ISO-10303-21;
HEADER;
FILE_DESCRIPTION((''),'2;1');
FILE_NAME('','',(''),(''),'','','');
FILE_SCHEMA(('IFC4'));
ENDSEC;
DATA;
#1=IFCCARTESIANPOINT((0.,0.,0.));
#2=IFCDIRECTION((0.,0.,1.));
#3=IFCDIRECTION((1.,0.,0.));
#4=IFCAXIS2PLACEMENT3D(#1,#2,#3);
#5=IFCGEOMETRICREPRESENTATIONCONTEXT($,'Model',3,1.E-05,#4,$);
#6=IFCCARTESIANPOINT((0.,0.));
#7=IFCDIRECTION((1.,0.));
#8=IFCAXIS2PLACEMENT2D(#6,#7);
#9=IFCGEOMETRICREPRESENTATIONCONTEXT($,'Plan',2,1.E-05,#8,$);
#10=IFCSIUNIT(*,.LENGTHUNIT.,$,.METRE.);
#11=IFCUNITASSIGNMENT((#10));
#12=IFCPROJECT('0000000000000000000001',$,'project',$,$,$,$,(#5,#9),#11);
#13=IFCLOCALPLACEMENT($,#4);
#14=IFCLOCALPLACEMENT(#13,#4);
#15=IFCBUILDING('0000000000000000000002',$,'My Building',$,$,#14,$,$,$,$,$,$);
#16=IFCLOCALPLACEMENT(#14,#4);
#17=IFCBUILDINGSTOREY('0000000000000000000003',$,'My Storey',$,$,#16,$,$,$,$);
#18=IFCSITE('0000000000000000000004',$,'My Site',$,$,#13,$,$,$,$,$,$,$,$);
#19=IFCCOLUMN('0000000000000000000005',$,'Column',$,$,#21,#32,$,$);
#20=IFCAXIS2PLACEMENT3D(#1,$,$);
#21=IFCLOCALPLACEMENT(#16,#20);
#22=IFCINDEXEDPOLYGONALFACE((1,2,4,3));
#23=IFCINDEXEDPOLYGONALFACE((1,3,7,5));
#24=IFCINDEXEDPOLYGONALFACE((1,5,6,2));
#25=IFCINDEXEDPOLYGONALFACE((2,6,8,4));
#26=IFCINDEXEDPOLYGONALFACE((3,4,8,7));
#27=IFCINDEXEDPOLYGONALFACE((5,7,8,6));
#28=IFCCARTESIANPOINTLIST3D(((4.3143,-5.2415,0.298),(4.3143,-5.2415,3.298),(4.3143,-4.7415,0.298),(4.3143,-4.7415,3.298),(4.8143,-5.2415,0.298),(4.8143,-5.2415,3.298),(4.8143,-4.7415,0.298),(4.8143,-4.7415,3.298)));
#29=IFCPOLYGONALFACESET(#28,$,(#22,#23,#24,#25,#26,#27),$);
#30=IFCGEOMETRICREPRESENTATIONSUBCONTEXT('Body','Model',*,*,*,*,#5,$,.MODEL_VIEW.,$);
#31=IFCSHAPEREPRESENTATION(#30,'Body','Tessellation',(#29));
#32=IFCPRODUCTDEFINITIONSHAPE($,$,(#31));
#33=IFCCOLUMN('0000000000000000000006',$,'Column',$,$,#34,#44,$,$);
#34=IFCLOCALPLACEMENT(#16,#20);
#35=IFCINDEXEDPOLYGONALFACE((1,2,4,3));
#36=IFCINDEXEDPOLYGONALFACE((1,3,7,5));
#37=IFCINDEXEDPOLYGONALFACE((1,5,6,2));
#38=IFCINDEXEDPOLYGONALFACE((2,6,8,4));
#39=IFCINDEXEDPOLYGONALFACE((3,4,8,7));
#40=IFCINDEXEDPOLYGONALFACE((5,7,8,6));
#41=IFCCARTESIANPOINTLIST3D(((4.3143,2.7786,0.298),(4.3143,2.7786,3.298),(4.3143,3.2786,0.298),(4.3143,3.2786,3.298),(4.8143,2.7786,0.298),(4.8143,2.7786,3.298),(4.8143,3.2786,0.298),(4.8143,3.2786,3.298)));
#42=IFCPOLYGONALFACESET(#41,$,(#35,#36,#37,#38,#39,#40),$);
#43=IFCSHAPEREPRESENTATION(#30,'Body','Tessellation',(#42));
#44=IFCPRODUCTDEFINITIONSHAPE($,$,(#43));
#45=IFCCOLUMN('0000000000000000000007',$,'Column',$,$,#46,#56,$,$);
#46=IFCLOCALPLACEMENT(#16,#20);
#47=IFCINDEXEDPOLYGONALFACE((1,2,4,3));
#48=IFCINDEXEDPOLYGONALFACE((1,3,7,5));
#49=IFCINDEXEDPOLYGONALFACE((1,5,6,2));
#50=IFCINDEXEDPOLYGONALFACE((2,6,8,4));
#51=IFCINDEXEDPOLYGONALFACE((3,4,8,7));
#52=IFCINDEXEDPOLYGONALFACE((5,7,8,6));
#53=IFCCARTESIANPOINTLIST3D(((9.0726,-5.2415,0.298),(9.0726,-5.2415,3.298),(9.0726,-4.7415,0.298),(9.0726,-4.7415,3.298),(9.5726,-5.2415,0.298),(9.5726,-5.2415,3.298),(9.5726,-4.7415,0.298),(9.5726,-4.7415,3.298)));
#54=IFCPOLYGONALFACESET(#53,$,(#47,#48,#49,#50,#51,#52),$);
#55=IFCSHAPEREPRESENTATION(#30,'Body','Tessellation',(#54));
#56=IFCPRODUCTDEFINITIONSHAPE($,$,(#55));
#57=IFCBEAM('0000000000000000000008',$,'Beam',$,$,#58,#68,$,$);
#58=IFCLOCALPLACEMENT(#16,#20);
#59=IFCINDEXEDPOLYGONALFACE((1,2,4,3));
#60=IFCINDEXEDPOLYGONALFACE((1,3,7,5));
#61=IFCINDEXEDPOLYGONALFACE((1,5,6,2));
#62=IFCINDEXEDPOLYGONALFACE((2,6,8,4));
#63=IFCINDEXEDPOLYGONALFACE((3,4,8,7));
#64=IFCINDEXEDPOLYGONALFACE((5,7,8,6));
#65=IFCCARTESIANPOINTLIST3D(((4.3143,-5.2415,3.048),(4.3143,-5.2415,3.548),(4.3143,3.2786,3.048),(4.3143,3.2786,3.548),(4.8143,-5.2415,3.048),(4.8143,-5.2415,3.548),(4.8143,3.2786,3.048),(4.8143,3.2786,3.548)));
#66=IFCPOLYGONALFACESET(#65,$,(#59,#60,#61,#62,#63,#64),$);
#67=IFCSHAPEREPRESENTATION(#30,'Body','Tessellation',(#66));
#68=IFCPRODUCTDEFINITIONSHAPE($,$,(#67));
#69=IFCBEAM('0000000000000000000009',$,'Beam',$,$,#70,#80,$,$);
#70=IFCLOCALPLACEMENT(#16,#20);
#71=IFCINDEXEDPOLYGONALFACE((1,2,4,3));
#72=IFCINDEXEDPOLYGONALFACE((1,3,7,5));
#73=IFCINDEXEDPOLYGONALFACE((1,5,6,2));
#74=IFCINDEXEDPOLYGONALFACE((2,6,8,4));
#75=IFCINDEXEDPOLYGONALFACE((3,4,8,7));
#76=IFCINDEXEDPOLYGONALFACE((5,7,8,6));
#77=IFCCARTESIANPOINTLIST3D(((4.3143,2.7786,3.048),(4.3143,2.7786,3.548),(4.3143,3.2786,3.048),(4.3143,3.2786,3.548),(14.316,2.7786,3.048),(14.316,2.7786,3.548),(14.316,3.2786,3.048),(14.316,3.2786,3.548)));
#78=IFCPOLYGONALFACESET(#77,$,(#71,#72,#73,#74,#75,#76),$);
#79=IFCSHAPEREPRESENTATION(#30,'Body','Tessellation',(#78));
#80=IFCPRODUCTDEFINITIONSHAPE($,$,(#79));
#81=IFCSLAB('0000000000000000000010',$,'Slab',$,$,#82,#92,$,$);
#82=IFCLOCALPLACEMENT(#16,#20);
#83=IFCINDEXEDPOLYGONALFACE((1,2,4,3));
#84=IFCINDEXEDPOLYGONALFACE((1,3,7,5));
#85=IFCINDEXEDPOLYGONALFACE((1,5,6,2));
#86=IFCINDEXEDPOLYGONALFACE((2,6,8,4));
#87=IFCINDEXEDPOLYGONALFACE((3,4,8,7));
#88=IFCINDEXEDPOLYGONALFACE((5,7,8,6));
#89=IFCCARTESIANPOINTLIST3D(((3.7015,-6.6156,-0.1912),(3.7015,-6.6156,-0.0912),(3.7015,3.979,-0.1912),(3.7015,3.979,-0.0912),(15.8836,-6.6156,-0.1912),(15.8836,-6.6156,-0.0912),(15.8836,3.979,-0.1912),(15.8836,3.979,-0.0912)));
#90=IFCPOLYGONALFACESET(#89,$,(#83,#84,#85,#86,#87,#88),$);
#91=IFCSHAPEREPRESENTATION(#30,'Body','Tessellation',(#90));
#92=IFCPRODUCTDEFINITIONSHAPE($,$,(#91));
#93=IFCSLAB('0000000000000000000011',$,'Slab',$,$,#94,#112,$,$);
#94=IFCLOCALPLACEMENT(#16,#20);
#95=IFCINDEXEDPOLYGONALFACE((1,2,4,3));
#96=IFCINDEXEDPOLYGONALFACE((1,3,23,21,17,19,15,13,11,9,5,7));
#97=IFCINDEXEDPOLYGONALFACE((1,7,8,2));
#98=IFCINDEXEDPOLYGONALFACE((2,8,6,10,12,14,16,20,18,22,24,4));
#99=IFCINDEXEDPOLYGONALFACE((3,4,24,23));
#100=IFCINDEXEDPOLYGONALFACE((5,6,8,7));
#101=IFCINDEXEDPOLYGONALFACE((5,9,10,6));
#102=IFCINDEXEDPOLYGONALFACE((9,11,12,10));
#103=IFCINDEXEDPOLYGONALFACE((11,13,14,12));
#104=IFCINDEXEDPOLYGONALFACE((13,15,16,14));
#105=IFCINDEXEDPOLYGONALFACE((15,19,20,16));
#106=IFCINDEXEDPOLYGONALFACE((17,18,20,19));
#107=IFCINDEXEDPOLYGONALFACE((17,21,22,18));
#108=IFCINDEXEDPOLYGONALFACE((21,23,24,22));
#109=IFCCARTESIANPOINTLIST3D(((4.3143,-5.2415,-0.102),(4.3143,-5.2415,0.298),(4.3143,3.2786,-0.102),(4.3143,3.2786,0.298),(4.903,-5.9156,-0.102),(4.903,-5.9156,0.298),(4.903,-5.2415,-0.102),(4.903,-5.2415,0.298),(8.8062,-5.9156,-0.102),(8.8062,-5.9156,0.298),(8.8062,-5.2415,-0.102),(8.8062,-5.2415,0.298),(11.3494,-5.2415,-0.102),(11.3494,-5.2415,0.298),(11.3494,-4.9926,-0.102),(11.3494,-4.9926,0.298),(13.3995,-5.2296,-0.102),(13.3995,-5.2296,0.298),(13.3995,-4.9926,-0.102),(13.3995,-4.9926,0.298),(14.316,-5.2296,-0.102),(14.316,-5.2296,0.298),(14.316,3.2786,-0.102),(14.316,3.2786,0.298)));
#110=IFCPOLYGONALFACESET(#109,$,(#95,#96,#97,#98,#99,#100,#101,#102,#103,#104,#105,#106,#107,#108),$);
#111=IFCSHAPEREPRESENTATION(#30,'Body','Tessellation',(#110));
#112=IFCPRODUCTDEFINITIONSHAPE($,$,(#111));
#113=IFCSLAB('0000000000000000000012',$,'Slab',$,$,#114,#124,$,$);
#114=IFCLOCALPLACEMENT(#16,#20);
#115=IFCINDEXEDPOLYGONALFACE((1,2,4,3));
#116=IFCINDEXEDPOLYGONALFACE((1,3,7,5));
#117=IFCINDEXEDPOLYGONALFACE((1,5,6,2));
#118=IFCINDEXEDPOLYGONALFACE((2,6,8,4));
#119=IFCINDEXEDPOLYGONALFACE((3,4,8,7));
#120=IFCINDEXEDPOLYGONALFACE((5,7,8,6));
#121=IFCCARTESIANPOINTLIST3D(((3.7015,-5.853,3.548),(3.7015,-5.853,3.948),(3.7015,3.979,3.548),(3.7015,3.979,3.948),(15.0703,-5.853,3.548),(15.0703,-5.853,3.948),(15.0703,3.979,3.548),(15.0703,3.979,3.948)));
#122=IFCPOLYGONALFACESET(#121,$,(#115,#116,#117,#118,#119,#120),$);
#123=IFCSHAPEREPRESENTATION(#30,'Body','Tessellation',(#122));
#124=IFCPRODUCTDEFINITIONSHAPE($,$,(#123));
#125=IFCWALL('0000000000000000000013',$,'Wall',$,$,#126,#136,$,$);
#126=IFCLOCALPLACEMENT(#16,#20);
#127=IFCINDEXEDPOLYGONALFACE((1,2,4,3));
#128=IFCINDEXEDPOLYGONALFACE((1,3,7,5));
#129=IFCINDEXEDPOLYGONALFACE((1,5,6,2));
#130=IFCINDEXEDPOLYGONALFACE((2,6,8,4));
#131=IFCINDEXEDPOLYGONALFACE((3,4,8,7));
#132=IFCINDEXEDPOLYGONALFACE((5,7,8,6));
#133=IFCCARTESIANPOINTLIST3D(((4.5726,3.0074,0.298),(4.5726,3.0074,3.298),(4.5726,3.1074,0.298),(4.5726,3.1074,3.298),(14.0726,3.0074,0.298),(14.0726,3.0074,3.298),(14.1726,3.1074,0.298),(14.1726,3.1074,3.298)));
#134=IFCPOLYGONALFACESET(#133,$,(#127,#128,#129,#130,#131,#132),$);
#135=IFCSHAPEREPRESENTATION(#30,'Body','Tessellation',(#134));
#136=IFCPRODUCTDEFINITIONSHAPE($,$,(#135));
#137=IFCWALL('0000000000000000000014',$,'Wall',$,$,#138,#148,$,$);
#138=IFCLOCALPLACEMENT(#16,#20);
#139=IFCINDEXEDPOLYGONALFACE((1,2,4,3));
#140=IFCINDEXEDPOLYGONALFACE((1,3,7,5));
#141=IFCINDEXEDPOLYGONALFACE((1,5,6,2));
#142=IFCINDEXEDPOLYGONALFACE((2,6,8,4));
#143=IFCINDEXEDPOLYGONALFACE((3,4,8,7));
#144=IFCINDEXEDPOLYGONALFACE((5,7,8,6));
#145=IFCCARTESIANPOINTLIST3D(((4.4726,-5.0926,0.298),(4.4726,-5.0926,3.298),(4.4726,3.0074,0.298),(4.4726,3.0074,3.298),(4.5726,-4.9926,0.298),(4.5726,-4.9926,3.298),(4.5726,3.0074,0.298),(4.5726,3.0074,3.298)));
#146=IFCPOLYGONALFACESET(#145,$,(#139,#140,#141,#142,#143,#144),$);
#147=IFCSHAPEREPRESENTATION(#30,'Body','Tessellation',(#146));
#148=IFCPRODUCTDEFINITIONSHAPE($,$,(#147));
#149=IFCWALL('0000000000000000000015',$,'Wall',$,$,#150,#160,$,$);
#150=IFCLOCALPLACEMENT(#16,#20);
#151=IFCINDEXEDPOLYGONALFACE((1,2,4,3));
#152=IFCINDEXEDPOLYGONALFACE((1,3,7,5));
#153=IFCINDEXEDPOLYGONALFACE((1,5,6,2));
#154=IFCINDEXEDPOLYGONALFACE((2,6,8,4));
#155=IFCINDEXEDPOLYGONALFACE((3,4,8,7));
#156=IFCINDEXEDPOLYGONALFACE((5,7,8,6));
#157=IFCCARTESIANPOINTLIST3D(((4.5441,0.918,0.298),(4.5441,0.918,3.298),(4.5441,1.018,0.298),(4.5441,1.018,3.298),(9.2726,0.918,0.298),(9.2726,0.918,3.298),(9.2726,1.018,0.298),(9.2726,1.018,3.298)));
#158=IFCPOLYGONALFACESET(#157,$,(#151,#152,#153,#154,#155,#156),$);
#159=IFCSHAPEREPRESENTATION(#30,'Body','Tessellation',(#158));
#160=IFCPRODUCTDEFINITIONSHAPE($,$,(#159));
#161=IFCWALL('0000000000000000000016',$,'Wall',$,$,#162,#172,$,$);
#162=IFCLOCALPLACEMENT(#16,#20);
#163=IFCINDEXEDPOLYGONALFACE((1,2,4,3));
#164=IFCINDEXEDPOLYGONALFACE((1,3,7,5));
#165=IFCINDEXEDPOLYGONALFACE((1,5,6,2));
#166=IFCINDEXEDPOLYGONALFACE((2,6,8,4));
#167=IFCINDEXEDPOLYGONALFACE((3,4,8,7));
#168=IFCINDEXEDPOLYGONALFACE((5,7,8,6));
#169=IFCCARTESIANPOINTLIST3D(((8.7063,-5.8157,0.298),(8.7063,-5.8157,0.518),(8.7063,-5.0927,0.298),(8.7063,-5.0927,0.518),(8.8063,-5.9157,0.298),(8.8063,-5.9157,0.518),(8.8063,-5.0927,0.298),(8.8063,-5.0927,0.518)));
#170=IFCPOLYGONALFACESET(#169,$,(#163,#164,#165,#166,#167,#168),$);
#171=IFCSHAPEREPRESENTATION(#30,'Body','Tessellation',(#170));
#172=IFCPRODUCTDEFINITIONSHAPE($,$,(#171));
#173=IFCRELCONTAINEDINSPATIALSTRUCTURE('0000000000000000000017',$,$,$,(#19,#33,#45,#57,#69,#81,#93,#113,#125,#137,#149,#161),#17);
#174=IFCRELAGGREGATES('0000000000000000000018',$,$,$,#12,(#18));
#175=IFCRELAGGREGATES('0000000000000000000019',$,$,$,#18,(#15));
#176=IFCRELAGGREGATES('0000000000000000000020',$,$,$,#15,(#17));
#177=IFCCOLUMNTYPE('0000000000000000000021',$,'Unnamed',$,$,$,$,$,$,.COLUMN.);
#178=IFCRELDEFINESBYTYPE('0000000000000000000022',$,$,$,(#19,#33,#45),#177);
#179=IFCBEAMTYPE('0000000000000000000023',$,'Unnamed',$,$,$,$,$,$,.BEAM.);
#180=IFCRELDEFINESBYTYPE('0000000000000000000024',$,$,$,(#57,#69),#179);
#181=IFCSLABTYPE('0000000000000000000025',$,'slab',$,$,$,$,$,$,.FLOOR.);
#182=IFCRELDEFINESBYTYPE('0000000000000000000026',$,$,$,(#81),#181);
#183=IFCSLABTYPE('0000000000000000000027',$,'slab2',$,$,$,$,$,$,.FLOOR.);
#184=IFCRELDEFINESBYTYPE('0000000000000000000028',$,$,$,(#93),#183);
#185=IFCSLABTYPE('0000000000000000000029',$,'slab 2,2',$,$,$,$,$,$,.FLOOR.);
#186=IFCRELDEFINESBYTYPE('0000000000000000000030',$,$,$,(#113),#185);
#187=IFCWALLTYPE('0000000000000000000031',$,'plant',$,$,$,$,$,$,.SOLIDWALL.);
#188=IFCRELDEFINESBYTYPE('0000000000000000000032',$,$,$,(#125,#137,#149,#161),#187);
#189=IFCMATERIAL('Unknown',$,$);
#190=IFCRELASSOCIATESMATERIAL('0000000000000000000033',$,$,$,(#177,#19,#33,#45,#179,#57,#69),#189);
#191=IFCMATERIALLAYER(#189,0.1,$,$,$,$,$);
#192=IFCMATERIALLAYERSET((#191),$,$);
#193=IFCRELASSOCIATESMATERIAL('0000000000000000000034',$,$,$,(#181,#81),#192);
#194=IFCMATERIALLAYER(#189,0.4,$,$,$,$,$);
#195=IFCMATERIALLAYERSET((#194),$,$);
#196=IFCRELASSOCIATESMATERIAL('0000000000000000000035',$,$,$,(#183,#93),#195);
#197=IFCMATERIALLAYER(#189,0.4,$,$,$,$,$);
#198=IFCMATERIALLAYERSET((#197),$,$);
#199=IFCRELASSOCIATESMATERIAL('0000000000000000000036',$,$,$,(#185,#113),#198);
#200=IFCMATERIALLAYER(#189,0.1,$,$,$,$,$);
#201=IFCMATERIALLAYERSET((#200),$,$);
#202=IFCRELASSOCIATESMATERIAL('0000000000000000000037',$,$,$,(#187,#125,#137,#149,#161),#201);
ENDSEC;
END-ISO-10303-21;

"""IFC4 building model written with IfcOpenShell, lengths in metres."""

from ifc_helpers import new_model, si_unit, frame, origin_with_axes, origin_2d_with_axis, place, context, subcontext, project, spatial, line, indexed_curve, outline, extrude, material, layer, layer_set, layer_usage, material_profile, profile_set, profile_usage, type_object, element, save


model = new_model("IFC4")

# Units and contexts
model_context = context("Model", 3, precision=1e-05, world=origin_with_axes())
plan_context = context("Plan", 2, precision=1e-05, world=origin_2d_with_axis())
body_context_1 = subcontext(model_context, "Body", "Model", "MODEL_VIEW")
ifc_project = project(units=[si_unit("LENGTHUNIT", "METRE")], contexts=[model_context, plan_context])

# Site, building, storey
site_placement = place(None, origin_with_axes())
site = spatial("IfcSite", under=ifc_project, at=site_placement, Name="My Site")
building_placement = place(site_placement, origin_with_axes())
building = spatial("IfcBuilding", under=site, at=building_placement, Name="My Building")
storey_placement = place(building_placement, origin_with_axes())
storey = spatial("IfcBuildingStorey", under=building, at=storey_placement, Name="My Storey")

# Columns
ifc_material = material(Name="Unknown")
ifc_material_profile_1 = material_profile(ifc_material, outline(indexed_curve([(-0.25, 0.25), (0.25, 0.25), (0.25, -0.25), (-0.25, -0.25), (-0.25, 0.25)])))
ifc_profile_set_1 = profile_set([ifc_material_profile_1])
ifc_profile_usage_1 = profile_usage(ifc_profile_set_1, cardinal=5)
column_type = type_object("IfcColumnType", Name="Unnamed", PredefinedType="COLUMN", material=ifc_profile_set_1)
column_1_placement = place(storey_placement, frame((4.5643, -4.9915, 0.298), z_axis=(0.0, 0.0, 1.0), x_axis=(1.0, 0.0, 0.0)))
element("IfcColumn", 1, at=column_1_placement, inside=storey, type_object=column_type, material=ifc_profile_usage_1, Name="Column", context=body_context_1, shape_type="SweptSolid", body=[
    extrude(outline(indexed_curve([(-0.25, 0.25), (0.25, 0.25), (0.25, -0.25), (-0.25, -0.25), (-0.25, 0.25)])), origin_with_axes(), (0.0, 0.0, 1.0), 3.0),
])
ifc_profile_usage_2 = profile_usage(ifc_profile_set_1, cardinal=5)
column_2_placement = place(storey_placement, frame((4.5643, 3.0286, 0.298), z_axis=(0.0, 0.0, 1.0), x_axis=(1.0, 0.0, 0.0)))
element("IfcColumn", 2, at=column_2_placement, inside=storey, type_object=column_type, material=ifc_profile_usage_2, Name="Column", context=body_context_1, shape_type="SweptSolid", body=[
    extrude(outline(indexed_curve([(-0.25, 0.25), (0.25, 0.25), (0.25, -0.25), (-0.25, -0.25), (-0.25, 0.25)])), origin_with_axes(), (0.0, 0.0, 1.0), 3.0),
])
ifc_profile_usage_3 = profile_usage(ifc_profile_set_1, cardinal=5)
column_3_placement = place(storey_placement, frame((9.3226, -4.9915, 0.298), z_axis=(0.0, 0.0, 1.0), x_axis=(1.0, 0.0, 0.0)))
element("IfcColumn", 3, at=column_3_placement, inside=storey, type_object=column_type, material=ifc_profile_usage_3, Name="Column", context=body_context_1, shape_type="SweptSolid", body=[
    extrude(outline(indexed_curve([(-0.25, 0.25), (0.25, 0.25), (0.25, -0.25), (-0.25, -0.25), (-0.25, 0.25)])), origin_with_axes(), (0.0, 0.0, 1.0), 3.0),
])

# Beams
ifc_material_profile_2 = material_profile(ifc_material, outline(indexed_curve([(-0.25, 0.25), (0.25, 0.25), (0.25, -0.25), (-0.25, -0.25), (-0.25, 0.25)])))
ifc_profile_set_2 = profile_set([ifc_material_profile_2])
ifc_profile_usage_4 = profile_usage(ifc_profile_set_2, cardinal=5)
beam_type = type_object("IfcBeamType", Name="Unnamed", PredefinedType="BEAM", material=ifc_profile_set_2)
beam_1_placement = place(storey_placement, frame((4.5643, 3.2786, 3.298), z_axis=(0.0, -1.0, 0.0), x_axis=(1.0, 0.0, 0.0)))
element("IfcBeam", 4, at=beam_1_placement, inside=storey, type_object=beam_type, material=ifc_profile_usage_4, Name="Beam", context=body_context_1, shape_type="SweptSolid", body=[
    extrude(outline(indexed_curve([(-0.25, 0.25), (0.25, 0.25), (0.25, -0.25), (-0.25, -0.25), (-0.25, 0.25)])), origin_with_axes(), (0.0, 0.0, 1.0), 8.5201),
])
ifc_profile_usage_5 = profile_usage(ifc_profile_set_2, cardinal=5)
beam_2_placement = place(storey_placement, frame((4.3143, 3.0286, 3.298), z_axis=(1.0, 0.0, 0.0), x_axis=(0.0, 1.0, 0.0)))
element("IfcBeam", 5, at=beam_2_placement, inside=storey, type_object=beam_type, material=ifc_profile_usage_5, Name="Beam", context=body_context_1, shape_type="SweptSolid", body=[
    extrude(outline(indexed_curve([(-0.25, 0.25), (0.25, 0.25), (0.25, -0.25), (-0.25, -0.25), (-0.25, 0.25)])), origin_with_axes(), (0.0, 0.0, 1.0), 10.0017),
])

# Slabs
ifc_layer_1 = layer(ifc_material, 0.1)
ifc_layer_set_1 = layer_set([ifc_layer_1])
ifc_layer_usage_1 = layer_usage(ifc_layer_set_1, "AXIS3", "POSITIVE", -0.1)
slab_type_1 = type_object("IfcSlabType", Name="slab", PredefinedType="FLOOR", material=ifc_layer_set_1)
slab_1_placement = place(storey_placement, frame((3.7015, -6.6156, -0.0912), z_axis=(0.0, 0.0, 1.0), x_axis=(1.0, 0.0, 0.0)))
element("IfcSlab", 6, at=slab_1_placement, inside=storey, type_object=slab_type_1, material=ifc_layer_usage_1, Name="Slab", context=body_context_1, shape_type="SweptSolid", body=[
    extrude(outline(indexed_curve([(0.0, 0.0), (12.1821, 0.0), (12.1821, 10.5945), (0.0, 10.5945), (0.0, 0.0)])), frame((0.0, 0.0, -0.1), z_axis=(0.0, 0.0, 1.0), x_axis=(1.0, 0.0, 0.0)), (0.0, 0.0, 1.0), 0.1),
])
ifc_layer_2 = layer(ifc_material, 0.4)
ifc_layer_set_2 = layer_set([ifc_layer_2])
ifc_layer_usage_2 = layer_usage(ifc_layer_set_2, "AXIS3", "POSITIVE", -0.4)
slab_type_2 = type_object("IfcSlabType", Name="slab2", PredefinedType="FLOOR", material=ifc_layer_set_2)
slab_2_placement = place(storey_placement, frame((4.3143, -5.2415, 0.298), z_axis=(0.0, 0.0, 1.0), x_axis=(1.0, 0.0, 0.0)))
element("IfcSlab", 7, at=slab_2_placement, inside=storey, type_object=slab_type_2, material=ifc_layer_usage_2, Name="Slab", context=body_context_1, shape_type="SweptSolid", body=[
    extrude(outline(indexed_curve([(0.0, 0.0), (0.5887, 0.0), (0.5887, -0.6741), (4.4919, -0.6741), (4.4919, 0.0), (7.0352, 0.0), (7.0352, 0.2489), (9.0852, 0.2489), (9.0852, 0.0119), (10.0017, 0.0119), (10.0017, 8.5201), (0.0, 8.5201), (0.0, 0.0)])), frame((0.0, 0.0, -0.4), z_axis=(0.0, 0.0, 1.0), x_axis=(1.0, 0.0, 0.0)), (0.0, 0.0, 1.0), 0.4),
])
ifc_layer_3 = layer(ifc_material, 0.4)
ifc_layer_set_3 = layer_set([ifc_layer_3])
ifc_layer_usage_3 = layer_usage(ifc_layer_set_3, "AXIS3", "POSITIVE", -0.4)
slab_type_3 = type_object("IfcSlabType", Name="slab 2,2", PredefinedType="FLOOR", material=ifc_layer_set_3)
slab_3_placement = place(storey_placement, frame((3.7015, 3.979, 3.948), z_axis=(0.0, 0.0, 1.0), x_axis=(1.0, 0.0, 0.0)))
element("IfcSlab", 8, at=slab_3_placement, inside=storey, type_object=slab_type_3, material=ifc_layer_usage_3, Name="Slab", context=body_context_1, shape_type="SweptSolid", body=[
    extrude(outline(indexed_curve([(0.0, 0.0), (11.3688, 0.0), (11.3688, -9.8319), (0.0, -9.8319), (0.0, 0.0)])), frame((0.0, 0.0, -0.4), z_axis=(0.0, 0.0, 1.0), x_axis=(1.0, 0.0, 0.0)), (0.0, 0.0, 1.0), 0.4),
])

# Walls
ifc_layer_4 = layer(ifc_material, 0.1)
ifc_layer_set_4 = layer_set([ifc_layer_4])
ifc_layer_usage_4 = layer_usage(ifc_layer_set_4, "AXIS2", "POSITIVE", 0.0)
wall_type = type_object("IfcWallType", Name="plant", PredefinedType="SOLIDWALL", material=ifc_layer_set_4)
wall_1_placement = place(storey_placement, frame((4.5726, 3.0074, 0.298), z_axis=(0.0, 0.0, 1.0), x_axis=(1.0, 0.0, 0.0)))
element("IfcWall", 9, at=wall_1_placement, inside=storey, type_object=wall_type, material=ifc_layer_usage_4, Name="Wall", context=body_context_1, shape_type="SweptSolid", body=[
    extrude(outline(indexed_curve([(0.0, 0.0), (0.0, 0.1), (9.6, 0.1), (9.5, 0.0)], segments=[line(1, 2, 3, 4, 1)])), origin_with_axes(), (0.0, 0.0, 1.0), 3.0),
])
ifc_layer_usage_5 = layer_usage(ifc_layer_set_4, "AXIS2", "POSITIVE", 0.0)
wall_2_placement = place(storey_placement, frame((4.5726, -4.9926, 0.298), z_axis=(0.0, 0.0, 1.0), x_axis=(0.0, 1.0, 0.0)))
element("IfcWall", 10, at=wall_2_placement, inside=storey, type_object=wall_type, material=ifc_layer_usage_5, Name="Wall", context=body_context_1, shape_type="SweptSolid", body=[
    extrude(outline(indexed_curve([(0.0, 0.0), (-0.1, 0.1), (8.0, 0.1), (8.0, 0.0)], segments=[line(1, 2, 3, 4, 1)])), origin_with_axes(), (0.0, 0.0, 1.0), 3.0),
])
ifc_layer_usage_6 = layer_usage(ifc_layer_set_4, "AXIS2", "POSITIVE", 0.0)
wall_3_placement = place(storey_placement, frame((9.2726, 1.018, 0.298), z_axis=(0.0, 0.0, 1.0), x_axis=(-1.0, 0.0, 0.0)))
element("IfcWall", 11, at=wall_3_placement, inside=storey, type_object=wall_type, material=ifc_layer_usage_6, Name="Wall", context=body_context_1, shape_type="SweptSolid", body=[
    extrude(outline(indexed_curve([(0.0, 0.0), (0.0, 0.1), (4.7285, 0.1), (4.7285, 0.0)], segments=[line(1, 2, 3, 4, 1)])), origin_with_axes(), (0.0, 0.0, 1.0), 3.0),
])
ifc_layer_usage_7 = layer_usage(ifc_layer_set_4, "AXIS2", "POSITIVE", 0.0)
wall_4_placement = place(storey_placement, frame((8.7063, -5.0927, 0.298), z_axis=(0.0, 0.0, 1.0), x_axis=(0.0, -1.0, 0.0)))
element("IfcWall", 12, at=wall_4_placement, inside=storey, type_object=wall_type, material=ifc_layer_usage_7, Name="Wall", context=body_context_1, shape_type="SweptSolid", body=[
    extrude(outline(indexed_curve([(0.0, 0.0), (0.0, 0.1), (0.823, 0.1), (0.723, 0.0)], segments=[line(1, 2, 3, 4, 1)])), origin_with_axes(), (0.0, 0.0, 1.0), 0.22),
])

save(model, "model.ifc")
